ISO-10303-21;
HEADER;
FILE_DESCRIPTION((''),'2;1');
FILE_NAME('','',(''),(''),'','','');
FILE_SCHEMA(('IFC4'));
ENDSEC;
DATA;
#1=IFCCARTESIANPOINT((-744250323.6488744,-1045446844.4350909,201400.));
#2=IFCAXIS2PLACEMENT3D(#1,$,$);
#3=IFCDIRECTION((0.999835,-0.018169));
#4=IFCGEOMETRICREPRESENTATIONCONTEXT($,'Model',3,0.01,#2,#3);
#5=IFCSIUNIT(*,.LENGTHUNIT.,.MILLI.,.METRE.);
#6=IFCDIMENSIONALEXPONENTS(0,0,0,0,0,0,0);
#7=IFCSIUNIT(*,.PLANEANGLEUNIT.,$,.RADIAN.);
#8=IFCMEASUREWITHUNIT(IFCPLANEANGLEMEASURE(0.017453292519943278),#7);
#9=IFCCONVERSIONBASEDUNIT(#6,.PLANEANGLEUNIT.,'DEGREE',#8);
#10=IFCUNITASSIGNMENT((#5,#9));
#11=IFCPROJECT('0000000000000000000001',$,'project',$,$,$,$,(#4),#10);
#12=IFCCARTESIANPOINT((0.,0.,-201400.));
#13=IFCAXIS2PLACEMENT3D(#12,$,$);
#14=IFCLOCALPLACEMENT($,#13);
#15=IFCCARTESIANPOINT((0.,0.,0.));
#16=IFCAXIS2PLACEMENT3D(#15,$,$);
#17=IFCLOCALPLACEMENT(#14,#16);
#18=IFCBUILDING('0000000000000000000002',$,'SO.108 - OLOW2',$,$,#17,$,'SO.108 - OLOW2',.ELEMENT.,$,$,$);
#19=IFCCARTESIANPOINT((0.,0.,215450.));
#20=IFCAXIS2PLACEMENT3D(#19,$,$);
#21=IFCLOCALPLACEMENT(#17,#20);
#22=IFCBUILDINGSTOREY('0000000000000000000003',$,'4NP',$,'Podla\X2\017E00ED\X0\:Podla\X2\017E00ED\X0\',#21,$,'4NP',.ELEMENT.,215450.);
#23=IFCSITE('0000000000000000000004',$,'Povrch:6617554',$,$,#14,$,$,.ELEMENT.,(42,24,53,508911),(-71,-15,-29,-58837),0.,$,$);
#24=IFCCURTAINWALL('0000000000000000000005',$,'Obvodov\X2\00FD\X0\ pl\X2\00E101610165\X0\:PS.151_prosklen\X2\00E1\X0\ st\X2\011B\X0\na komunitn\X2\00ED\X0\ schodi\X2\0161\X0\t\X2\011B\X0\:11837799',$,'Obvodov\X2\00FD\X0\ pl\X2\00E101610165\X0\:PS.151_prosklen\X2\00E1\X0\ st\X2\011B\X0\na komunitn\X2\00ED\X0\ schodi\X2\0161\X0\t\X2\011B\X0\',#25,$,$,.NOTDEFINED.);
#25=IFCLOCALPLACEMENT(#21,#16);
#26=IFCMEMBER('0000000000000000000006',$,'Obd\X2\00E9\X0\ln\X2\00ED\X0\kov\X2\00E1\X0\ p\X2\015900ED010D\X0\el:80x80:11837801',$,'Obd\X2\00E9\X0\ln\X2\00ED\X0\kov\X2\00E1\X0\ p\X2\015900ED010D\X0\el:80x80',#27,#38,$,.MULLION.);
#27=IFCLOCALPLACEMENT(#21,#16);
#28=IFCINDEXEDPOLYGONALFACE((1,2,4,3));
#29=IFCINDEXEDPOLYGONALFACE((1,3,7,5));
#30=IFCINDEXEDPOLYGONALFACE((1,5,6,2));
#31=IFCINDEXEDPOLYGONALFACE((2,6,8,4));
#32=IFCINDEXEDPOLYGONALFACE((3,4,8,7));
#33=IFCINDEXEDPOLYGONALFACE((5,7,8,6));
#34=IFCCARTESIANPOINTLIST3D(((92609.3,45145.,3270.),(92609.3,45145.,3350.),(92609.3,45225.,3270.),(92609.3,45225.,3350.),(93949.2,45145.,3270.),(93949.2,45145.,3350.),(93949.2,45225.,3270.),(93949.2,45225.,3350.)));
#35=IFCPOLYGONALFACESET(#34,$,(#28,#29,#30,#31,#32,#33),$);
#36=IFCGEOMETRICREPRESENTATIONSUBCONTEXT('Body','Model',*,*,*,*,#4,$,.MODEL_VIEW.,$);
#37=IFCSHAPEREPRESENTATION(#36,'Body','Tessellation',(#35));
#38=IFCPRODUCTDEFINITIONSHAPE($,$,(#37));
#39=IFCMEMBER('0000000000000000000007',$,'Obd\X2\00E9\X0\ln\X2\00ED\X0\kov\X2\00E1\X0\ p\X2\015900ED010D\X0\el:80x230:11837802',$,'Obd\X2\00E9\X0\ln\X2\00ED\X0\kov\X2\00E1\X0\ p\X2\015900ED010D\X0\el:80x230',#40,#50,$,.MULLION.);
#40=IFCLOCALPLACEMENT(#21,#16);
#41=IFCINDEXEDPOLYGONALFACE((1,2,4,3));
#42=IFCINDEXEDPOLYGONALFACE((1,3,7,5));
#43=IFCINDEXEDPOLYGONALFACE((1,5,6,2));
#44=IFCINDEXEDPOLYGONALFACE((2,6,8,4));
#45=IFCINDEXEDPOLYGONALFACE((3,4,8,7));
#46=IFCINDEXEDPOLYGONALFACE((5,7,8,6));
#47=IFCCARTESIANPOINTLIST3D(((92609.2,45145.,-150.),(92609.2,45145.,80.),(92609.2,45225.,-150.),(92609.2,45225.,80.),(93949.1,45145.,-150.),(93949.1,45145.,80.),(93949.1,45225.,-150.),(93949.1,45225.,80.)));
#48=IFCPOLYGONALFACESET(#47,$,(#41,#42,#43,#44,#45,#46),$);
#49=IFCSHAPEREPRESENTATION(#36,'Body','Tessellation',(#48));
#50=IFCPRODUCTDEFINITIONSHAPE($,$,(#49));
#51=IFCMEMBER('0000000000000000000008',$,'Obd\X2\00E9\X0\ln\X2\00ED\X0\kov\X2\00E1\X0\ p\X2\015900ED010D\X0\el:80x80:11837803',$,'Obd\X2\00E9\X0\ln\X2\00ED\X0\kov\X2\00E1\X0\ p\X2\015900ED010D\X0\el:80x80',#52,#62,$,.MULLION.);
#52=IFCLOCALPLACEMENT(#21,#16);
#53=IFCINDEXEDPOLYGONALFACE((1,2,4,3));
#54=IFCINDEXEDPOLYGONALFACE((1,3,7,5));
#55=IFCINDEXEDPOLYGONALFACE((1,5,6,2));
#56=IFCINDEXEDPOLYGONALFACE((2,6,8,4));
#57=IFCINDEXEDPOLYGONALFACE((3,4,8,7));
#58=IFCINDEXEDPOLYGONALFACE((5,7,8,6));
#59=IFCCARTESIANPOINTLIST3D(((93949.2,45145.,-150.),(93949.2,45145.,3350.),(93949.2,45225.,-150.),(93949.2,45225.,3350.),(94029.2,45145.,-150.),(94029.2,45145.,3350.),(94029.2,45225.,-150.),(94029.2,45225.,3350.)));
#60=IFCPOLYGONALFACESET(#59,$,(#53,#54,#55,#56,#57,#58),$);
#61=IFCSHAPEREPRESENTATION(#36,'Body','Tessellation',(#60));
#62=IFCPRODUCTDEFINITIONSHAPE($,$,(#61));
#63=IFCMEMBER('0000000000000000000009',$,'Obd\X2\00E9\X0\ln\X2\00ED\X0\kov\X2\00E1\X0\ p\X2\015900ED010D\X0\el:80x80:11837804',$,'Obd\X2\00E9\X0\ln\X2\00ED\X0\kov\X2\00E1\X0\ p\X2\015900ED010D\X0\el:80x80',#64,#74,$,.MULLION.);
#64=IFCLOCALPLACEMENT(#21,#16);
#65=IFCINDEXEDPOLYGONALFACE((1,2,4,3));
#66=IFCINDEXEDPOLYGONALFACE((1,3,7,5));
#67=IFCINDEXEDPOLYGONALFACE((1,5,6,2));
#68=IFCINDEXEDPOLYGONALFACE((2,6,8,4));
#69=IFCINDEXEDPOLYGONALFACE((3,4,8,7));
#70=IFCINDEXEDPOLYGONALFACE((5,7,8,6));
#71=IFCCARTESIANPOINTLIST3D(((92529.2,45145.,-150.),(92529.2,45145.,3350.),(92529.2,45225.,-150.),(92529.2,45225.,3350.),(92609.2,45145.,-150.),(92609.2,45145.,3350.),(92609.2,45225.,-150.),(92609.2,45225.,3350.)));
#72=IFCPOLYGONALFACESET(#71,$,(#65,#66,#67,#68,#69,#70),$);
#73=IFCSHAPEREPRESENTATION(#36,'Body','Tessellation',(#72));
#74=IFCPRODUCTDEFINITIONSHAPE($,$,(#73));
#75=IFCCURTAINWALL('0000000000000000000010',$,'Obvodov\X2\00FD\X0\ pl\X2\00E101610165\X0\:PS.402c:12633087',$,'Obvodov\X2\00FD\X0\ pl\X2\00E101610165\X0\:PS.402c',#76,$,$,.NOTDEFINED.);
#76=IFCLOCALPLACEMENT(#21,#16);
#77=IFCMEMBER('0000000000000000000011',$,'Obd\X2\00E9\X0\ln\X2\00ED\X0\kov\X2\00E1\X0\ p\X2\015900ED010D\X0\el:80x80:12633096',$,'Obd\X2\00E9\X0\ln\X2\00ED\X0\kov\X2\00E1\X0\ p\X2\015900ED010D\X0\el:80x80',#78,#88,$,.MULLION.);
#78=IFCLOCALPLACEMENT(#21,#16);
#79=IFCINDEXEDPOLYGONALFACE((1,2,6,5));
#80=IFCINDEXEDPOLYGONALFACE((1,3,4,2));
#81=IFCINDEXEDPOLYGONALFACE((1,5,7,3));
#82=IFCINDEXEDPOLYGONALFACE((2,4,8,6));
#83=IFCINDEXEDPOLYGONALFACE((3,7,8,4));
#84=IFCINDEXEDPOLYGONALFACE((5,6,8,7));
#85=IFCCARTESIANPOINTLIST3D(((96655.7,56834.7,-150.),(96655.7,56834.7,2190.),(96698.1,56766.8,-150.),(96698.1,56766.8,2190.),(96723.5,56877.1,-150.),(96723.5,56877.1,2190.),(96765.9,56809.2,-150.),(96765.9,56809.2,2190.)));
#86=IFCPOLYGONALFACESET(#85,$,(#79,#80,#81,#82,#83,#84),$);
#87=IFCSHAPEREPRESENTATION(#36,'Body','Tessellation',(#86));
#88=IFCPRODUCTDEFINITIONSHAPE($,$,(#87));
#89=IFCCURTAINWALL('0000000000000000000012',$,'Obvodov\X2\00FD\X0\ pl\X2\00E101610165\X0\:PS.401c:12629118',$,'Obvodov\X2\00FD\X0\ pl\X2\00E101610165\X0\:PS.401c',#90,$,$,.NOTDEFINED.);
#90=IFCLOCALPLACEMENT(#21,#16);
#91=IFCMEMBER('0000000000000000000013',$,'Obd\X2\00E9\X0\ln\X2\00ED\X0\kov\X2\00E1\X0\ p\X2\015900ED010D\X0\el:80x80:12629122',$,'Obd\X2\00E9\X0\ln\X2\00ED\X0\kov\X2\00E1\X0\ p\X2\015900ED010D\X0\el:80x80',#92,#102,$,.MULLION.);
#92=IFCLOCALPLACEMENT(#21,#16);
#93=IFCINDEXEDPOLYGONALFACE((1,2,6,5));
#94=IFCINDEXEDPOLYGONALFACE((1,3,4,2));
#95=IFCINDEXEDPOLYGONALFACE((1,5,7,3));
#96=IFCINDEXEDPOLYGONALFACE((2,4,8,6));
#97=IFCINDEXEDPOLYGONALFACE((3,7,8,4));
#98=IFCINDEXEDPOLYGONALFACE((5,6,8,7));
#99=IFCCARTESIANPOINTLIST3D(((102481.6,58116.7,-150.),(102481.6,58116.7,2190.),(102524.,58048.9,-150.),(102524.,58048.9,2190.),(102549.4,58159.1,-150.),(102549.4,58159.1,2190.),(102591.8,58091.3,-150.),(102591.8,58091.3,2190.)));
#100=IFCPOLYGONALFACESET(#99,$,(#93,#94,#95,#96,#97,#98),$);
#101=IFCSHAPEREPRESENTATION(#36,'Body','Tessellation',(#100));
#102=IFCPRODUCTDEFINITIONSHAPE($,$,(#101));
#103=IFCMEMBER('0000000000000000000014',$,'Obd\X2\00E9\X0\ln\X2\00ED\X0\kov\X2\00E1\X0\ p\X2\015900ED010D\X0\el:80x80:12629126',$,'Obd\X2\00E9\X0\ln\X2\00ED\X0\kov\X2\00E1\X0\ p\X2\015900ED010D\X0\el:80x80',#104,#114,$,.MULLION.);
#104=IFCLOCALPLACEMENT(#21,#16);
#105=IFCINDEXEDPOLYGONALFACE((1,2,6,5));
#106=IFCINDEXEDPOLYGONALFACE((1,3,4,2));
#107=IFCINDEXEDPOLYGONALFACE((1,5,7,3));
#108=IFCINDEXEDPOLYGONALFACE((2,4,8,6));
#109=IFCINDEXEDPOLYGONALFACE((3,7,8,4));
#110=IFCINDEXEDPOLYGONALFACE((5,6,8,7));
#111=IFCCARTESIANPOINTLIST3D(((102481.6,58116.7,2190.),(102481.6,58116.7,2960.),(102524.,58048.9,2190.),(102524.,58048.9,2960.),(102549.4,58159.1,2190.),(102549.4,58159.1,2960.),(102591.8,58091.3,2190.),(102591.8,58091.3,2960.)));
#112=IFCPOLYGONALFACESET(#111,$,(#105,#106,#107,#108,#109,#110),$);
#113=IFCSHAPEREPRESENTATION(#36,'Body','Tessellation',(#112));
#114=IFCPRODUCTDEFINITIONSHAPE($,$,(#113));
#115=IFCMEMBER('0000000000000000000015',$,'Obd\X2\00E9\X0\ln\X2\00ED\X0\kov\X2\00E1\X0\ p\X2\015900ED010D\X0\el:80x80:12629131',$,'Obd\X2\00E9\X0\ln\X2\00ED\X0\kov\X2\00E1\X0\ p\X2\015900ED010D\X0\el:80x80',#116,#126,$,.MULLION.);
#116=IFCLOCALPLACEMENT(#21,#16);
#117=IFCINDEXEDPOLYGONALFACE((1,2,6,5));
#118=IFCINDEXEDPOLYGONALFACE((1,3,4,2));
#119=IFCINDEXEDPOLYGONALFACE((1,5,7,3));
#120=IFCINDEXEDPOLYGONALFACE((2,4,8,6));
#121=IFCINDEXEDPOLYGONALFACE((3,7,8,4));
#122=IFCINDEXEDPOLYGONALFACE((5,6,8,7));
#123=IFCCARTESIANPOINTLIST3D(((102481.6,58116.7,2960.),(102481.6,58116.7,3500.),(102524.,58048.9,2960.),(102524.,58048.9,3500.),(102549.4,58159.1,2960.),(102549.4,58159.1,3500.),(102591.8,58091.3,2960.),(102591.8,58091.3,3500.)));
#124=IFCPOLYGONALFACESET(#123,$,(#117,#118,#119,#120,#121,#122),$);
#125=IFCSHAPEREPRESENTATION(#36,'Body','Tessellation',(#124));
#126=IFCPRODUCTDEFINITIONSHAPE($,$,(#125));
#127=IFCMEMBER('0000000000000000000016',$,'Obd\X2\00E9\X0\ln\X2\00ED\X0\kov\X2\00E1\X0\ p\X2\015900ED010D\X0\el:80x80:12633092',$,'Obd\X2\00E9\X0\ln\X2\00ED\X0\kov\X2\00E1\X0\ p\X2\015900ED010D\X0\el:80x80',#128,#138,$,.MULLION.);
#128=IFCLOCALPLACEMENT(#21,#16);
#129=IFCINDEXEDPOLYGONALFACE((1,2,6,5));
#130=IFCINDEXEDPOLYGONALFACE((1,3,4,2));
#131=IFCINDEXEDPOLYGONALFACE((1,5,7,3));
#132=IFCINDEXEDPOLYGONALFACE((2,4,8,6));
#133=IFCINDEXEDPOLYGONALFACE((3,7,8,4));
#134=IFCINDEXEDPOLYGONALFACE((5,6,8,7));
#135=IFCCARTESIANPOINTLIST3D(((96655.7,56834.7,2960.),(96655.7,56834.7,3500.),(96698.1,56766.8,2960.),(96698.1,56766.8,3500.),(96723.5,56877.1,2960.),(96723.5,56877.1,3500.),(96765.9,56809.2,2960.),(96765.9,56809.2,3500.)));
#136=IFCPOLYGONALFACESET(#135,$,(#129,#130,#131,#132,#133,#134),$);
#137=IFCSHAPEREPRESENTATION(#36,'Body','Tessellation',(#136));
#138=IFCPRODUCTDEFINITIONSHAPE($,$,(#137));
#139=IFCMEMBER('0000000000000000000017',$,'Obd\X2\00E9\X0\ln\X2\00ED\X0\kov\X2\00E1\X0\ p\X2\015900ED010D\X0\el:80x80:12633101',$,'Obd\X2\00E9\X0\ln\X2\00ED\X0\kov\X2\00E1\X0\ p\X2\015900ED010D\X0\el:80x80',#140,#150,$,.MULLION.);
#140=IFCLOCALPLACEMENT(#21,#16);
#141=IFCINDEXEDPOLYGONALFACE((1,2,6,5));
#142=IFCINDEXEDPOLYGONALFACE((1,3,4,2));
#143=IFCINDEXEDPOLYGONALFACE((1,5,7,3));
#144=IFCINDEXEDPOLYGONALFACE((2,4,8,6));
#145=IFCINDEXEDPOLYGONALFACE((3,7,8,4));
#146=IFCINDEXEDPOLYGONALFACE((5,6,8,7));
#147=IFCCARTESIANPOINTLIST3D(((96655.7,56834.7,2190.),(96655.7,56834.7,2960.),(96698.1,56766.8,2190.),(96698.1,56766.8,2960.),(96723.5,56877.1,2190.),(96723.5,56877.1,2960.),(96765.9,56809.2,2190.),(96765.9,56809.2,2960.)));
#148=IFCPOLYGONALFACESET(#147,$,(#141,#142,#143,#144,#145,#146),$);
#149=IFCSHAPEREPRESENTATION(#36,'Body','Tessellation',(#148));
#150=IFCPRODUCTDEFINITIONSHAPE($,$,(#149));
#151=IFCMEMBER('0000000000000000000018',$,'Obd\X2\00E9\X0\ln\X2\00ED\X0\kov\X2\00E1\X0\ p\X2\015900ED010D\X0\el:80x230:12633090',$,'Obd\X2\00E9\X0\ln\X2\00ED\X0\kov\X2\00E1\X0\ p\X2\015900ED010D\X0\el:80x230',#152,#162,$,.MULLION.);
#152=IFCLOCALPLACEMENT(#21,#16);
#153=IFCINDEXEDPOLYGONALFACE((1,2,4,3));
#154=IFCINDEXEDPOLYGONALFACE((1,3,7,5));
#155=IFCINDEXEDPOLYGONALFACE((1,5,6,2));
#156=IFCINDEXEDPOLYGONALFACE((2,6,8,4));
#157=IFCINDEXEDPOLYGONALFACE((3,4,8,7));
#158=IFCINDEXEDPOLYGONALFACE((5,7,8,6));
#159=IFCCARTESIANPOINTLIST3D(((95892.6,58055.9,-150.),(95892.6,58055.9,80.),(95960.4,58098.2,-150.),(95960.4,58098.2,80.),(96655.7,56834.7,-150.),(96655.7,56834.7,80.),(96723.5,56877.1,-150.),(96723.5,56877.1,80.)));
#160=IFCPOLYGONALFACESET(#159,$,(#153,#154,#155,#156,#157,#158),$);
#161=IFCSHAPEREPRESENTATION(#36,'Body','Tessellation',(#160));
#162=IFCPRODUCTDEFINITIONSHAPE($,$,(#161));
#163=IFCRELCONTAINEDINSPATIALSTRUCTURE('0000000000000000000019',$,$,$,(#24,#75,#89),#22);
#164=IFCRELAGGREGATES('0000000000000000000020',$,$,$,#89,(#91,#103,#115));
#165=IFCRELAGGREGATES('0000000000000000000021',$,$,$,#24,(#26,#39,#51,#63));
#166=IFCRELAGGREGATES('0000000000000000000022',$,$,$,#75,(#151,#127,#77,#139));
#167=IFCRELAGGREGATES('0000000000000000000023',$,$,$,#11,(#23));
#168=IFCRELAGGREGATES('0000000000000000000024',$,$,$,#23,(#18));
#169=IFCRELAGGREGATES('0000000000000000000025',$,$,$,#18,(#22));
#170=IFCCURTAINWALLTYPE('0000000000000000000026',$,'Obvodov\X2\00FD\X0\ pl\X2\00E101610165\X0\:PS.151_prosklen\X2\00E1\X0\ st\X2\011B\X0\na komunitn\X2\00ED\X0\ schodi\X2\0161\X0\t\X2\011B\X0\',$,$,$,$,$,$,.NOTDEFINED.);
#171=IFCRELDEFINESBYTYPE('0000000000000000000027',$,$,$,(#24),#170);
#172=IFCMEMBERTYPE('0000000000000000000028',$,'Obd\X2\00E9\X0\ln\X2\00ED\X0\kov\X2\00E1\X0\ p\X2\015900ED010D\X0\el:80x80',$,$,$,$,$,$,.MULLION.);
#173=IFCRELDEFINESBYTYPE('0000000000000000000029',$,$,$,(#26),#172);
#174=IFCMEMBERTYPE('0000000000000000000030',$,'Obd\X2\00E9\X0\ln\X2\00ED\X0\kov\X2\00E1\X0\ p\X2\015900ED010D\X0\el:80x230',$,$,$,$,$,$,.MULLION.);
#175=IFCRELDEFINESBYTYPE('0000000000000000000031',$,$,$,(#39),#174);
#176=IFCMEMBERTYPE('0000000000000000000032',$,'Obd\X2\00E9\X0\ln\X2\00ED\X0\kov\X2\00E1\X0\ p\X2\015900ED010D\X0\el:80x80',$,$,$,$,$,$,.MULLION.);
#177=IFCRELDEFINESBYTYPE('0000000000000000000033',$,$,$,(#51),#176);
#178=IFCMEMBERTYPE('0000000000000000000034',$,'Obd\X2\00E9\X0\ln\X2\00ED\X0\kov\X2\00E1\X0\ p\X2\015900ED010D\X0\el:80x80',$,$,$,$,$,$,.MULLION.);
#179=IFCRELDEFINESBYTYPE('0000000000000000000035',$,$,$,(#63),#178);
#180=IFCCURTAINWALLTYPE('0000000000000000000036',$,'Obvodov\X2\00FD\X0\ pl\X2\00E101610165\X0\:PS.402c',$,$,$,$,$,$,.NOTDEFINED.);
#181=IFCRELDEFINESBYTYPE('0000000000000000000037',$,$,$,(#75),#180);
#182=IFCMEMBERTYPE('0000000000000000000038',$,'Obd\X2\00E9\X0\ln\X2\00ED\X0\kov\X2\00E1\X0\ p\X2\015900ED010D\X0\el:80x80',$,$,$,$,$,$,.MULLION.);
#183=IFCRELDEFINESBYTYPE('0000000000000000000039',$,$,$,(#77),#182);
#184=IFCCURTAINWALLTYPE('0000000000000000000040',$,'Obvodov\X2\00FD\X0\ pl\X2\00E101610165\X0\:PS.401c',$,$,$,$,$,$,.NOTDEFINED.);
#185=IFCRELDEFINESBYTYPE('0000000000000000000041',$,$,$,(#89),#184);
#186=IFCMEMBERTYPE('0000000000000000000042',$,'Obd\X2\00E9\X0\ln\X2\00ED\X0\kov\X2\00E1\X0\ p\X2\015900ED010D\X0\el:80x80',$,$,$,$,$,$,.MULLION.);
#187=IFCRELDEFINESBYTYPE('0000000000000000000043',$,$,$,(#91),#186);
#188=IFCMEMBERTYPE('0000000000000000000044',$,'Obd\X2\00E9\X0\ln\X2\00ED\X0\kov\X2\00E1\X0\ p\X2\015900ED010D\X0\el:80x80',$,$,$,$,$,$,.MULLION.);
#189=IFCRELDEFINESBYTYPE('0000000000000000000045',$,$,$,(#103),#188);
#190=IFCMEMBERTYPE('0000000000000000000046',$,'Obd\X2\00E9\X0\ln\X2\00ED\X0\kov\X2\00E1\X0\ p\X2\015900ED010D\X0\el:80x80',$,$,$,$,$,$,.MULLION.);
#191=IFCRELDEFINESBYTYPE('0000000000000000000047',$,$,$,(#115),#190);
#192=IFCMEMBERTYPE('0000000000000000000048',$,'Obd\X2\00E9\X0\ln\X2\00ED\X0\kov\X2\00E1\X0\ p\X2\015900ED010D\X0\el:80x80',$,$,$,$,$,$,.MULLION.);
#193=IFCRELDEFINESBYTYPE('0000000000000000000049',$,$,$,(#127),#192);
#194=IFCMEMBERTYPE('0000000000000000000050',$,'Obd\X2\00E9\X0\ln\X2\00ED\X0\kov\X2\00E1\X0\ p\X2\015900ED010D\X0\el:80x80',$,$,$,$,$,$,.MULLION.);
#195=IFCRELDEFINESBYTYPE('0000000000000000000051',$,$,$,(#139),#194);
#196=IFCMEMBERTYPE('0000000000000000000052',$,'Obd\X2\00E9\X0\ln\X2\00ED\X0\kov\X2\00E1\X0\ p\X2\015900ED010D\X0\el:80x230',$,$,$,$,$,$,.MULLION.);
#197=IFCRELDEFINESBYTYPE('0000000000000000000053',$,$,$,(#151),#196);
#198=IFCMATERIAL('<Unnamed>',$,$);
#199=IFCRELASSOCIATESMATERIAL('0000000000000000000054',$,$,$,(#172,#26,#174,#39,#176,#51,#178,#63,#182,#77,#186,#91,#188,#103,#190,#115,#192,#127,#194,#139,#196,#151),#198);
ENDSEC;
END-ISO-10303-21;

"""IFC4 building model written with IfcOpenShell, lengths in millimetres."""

from ifc_helpers import new_model, entity, si_unit, converted_unit, direction, frame, origin, place, context, subcontext, project, spatial, indexed_curve, outline, extrude, source, transform, mapped, material, type_object, type_shapes, element, aggregate, save


model = new_model("IFC4")

# Units and contexts
model_context = context("Model", 3, precision=0.01, world=frame((-744250323.6488744, -1045446844.4350909, 201400.0)), true_north=direction((0.999835, -0.018169)))
body_context = subcontext(model_context, "Body", "Model", "MODEL_VIEW")
ifc_project = project(units=[si_unit("LENGTHUNIT", "METRE", prefix="MILLI"), converted_unit("PLANEANGLEUNIT", "DEGREE", entity("IfcPlaneAngleMeasure", 0.017453292519943278), si_unit("PLANEANGLEUNIT", "RADIAN"), dimensions=[0, 0, 0, 0, 0, 0, 0])], contexts=[model_context])

# Site, building, storey
site_placement = place(None, frame((0.0, 0.0, -201400.0)))
site = spatial("IfcSite", under=ifc_project, at=site_placement, Name="Povrch:6617554", CompositionType="ELEMENT", RefLatitude=(42, 24, 53, 508911), RefLongitude=(-71, -15, -29, -58837), RefElevation=0.0)
building_placement = place(site_placement, origin())
building = spatial("IfcBuilding", under=site, at=building_placement, Name="SO.108 - OLOW2", LongName="SO.108 - OLOW2", CompositionType="ELEMENT")
storey_placement = place(building_placement, frame((0.0, 0.0, 215450.0)))
storey = spatial("IfcBuildingStorey", under=building, at=storey_placement, Name="4NP", ObjectType="Podlaží:Podlaží", LongName="4NP", CompositionType="ELEMENT", Elevation=215450.0)

# Curtain wall, members
curtain_wall_type_1 = type_object("IfcCurtainWallType", Name="Obvodový plášť:PS.151_prosklená stěna komunitní schodiště", PredefinedType="NOTDEFINED")
curtain_wall_1_placement = place(storey_placement, frame((0.0, 0.0, -215450.0)))
curtain_wall_1 = element("IfcCurtainWall", 1, at=curtain_wall_1_placement, inside=storey, type_object=curtain_wall_type_1, Name="Obvodový plášť:PS.151_prosklená stěna komunitní schodiště:11837799", ObjectType="Obvodový plášť:PS.151_prosklená stěna komunitní schodiště", PredefinedType="NOTDEFINED")
ifc_material_1 = material(Name="<Unnamed>")
member_type_1 = type_object("IfcMemberType", Name="Obdélníková příčel:80x80", PredefinedType="MULLION", material=ifc_material_1)
shared_shape_1 = source(origin(), body_context, "Body", "SweptSolid", [
    extrude(outline(indexed_curve([(-40.0, -40.0), (40.0, -40.0), (40.0, 40.0), (-40.0, 40.0), (-40.0, -40.0)], self_intersect=False)), frame((-40.0, 0.0, -1339.9), z_axis=(0.0, 0.0, 1.0), x_axis=(-1.0, 0.0, 0.0)), (0.0, 0.0, 1.0), 1339.9),
])
type_shapes(member_type_1, [shared_shape_1])
member_1_placement = place(curtain_wall_1_placement, frame((93949.2, 45185.0, 218800.0), z_axis=(1.0, 0.0, 0.0), x_axis=(0.0, 0.0, 1.0)))
member_1 = element("IfcMember", 2, at=member_1_placement, type_object=member_type_1, material=ifc_material_1, Name="Obdélníková příčel:80x80:11837801", ObjectType="Obdélníková příčel:80x80", PredefinedType="MULLION", context=body_context, shape_type="MappedRepresentation", body=[
    mapped(shared_shape_1, transform((0.0, 0.0, 0.0), scale=1.0)),
])
member_type_2 = type_object("IfcMemberType", Name="Obdélníková příčel:80x230", PredefinedType="MULLION", material=ifc_material_1)
shared_shape_2 = source(origin(), body_context, "Body", "SweptSolid", [
    extrude(outline(indexed_curve([(-115.0, -40.0), (115.0, -40.0), (115.0, 40.0), (-115.0, 40.0), (-115.0, -40.0)], self_intersect=False)), frame((-115.0, 0.0, -1339.9), z_axis=(0.0, 0.0, 1.0), x_axis=(-1.0, 0.0, 0.0)), (0.0, 0.0, 1.0), 1339.9),
])
type_shapes(member_type_2, [shared_shape_2])
member_2_placement = place(curtain_wall_1_placement, frame((92609.2, 45185.0, 215300.0), z_axis=(-1.0, 0.0, 0.0), x_axis=(0.0, 0.0, -1.0)))
member_2 = element("IfcMember", 3, at=member_2_placement, type_object=member_type_2, material=ifc_material_1, Name="Obdélníková příčel:80x230:11837802", ObjectType="Obdélníková příčel:80x230", PredefinedType="MULLION", context=body_context, shape_type="MappedRepresentation", body=[
    mapped(shared_shape_2, transform((0.0, 0.0, 0.0), scale=1.0)),
])
member_type_3 = type_object("IfcMemberType", Name="Obdélníková příčel:80x80", PredefinedType="MULLION", material=ifc_material_1)
shared_shape_3 = source(origin(), body_context, "Body", "SweptSolid", [
    extrude(outline(indexed_curve([(-40.0, -40.0), (40.0, -40.0), (40.0, 40.0), (-40.0, 40.0), (-40.0, -40.0)], self_intersect=False)), frame((-40.0, 0.0, -3500.0), z_axis=(0.0, 0.0, 1.0), x_axis=(-1.0, 0.0, 0.0)), (0.0, 0.0, 1.0), 3500.0),
])
type_shapes(member_type_3, [shared_shape_3])
member_3_placement = place(curtain_wall_1_placement, frame((94029.2, 45185.0, 215300.0), z_axis=(0.0, 0.0, -1.0), x_axis=(1.0, 0.0, 0.0)))
member_3 = element("IfcMember", 4, at=member_3_placement, type_object=member_type_3, material=ifc_material_1, Name="Obdélníková příčel:80x80:11837803", ObjectType="Obdélníková příčel:80x80", PredefinedType="MULLION", context=body_context, shape_type="MappedRepresentation", body=[
    mapped(shared_shape_3, transform((0.0, 0.0, 0.0), scale=1.0)),
])
member_type_4 = type_object("IfcMemberType", Name="Obdélníková příčel:80x80", PredefinedType="MULLION", material=ifc_material_1)
shared_shape_4 = source(origin(), body_context, "Body", "SweptSolid", [
    extrude(outline(indexed_curve([(-40.0, -40.0), (40.0, -40.0), (40.0, 40.0), (-40.0, 40.0), (-40.0, -40.0)], self_intersect=False)), frame((-40.0, 0.0, -3500.0), z_axis=(0.0, 0.0, 1.0), x_axis=(-1.0, 0.0, 0.0)), (0.0, 0.0, 1.0), 3500.0),
])
type_shapes(member_type_4, [shared_shape_4])
member_4_placement = place(curtain_wall_1_placement, frame((92529.2, 45185.0, 218800.0), z_axis=(0.0, 0.0, 1.0), x_axis=(-1.0, 0.0, 0.0)))
member_4 = element("IfcMember", 5, at=member_4_placement, type_object=member_type_4, material=ifc_material_1, Name="Obdélníková příčel:80x80:11837804", ObjectType="Obdélníková příčel:80x80", PredefinedType="MULLION", context=body_context, shape_type="MappedRepresentation", body=[
    mapped(shared_shape_4, transform((0.0, 0.0, 0.0), scale=1.0)),
])

# Curtain wall, member
curtain_wall_type_2 = type_object("IfcCurtainWallType", Name="Obvodový plášť:PS.402c", PredefinedType="NOTDEFINED")
curtain_wall_2_placement = place(storey_placement, frame((0.0, 0.0, -215450.0)))
curtain_wall_2 = element("IfcCurtainWall", 6, at=curtain_wall_2_placement, inside=storey, type_object=curtain_wall_type_2, Name="Obvodový plášť:PS.402c:12633087", ObjectType="Obvodový plášť:PS.402c", PredefinedType="NOTDEFINED")
member_type_5 = type_object("IfcMemberType", Name="Obdélníková příčel:80x80", PredefinedType="MULLION", material=ifc_material_1)
shared_shape_5 = source(origin(), body_context, "Body", "SweptSolid", [
    extrude(outline(indexed_curve([(-40.0, -40.0), (40.0, -40.0), (40.0, 40.0), (-40.0, 40.0), (-40.0, -40.0)], self_intersect=False)), frame((-40.0, 0.0, -2340.0), z_axis=(0.0, 0.0, 1.0), x_axis=(-1.0, 0.0, 0.0)), (0.0, 0.0, 1.0), 2340.0),
])
type_shapes(member_type_5, [shared_shape_5])
member_5_placement = place(curtain_wall_2_placement, frame((96732.0, 56788.0, 217640.0), z_axis=(0.0, 0.0, 1.0), x_axis=(0.529919, -0.848048, 0.0)))
member_5 = element("IfcMember", 7, at=member_5_placement, type_object=member_type_5, material=ifc_material_1, Name="Obdélníková příčel:80x80:12633096", ObjectType="Obdélníková příčel:80x80", PredefinedType="MULLION", context=body_context, shape_type="MappedRepresentation", body=[
    mapped(shared_shape_5, transform((0.0, 0.0, 0.0), scale=1.0)),
])

# Curtain wall, members
curtain_wall_type_3 = type_object("IfcCurtainWallType", Name="Obvodový plášť:PS.401c", PredefinedType="NOTDEFINED")
curtain_wall_3_placement = place(storey_placement, frame((0.0, 0.0, -215450.0)))
curtain_wall_3 = element("IfcCurtainWall", 8, at=curtain_wall_3_placement, inside=storey, type_object=curtain_wall_type_3, Name="Obvodový plášť:PS.401c:12629118", ObjectType="Obvodový plášť:PS.401c", PredefinedType="NOTDEFINED")
member_type_6 = type_object("IfcMemberType", Name="Obdélníková příčel:80x80", PredefinedType="MULLION", material=ifc_material_1)
shared_shape_6 = source(origin(), body_context, "Body", "SweptSolid", [
    extrude(outline(indexed_curve([(-40.0, -40.0), (40.0, -40.0), (40.0, 40.0), (-40.0, 40.0), (-40.0, -40.0)], self_intersect=False)), frame((-40.0, 0.0, -2340.0), z_axis=(0.0, 0.0, 1.0), x_axis=(-1.0, 0.0, 0.0)), (0.0, 0.0, 1.0), 2340.0),
])
type_shapes(member_type_6, [shared_shape_6])
member_6_placement = place(curtain_wall_3_placement, frame((102557.9, 58070.1, 215300.0), z_axis=(0.0, 0.0, -1.0), x_axis=(0.529919, -0.848048, 0.0)))
member_6 = element("IfcMember", 9, at=member_6_placement, type_object=member_type_6, material=ifc_material_1, Name="Obdélníková příčel:80x80:12629122", ObjectType="Obdélníková příčel:80x80", PredefinedType="MULLION", context=body_context, shape_type="MappedRepresentation", body=[
    mapped(shared_shape_6, transform((0.0, 0.0, 0.0), scale=1.0)),
])
member_type_7 = type_object("IfcMemberType", Name="Obdélníková příčel:80x80", PredefinedType="MULLION", material=ifc_material_1)
shared_shape_7 = source(origin(), body_context, "Body", "SweptSolid", [
    extrude(outline(indexed_curve([(-40.0, -40.0), (40.0, -40.0), (40.0, 40.0), (-40.0, 40.0), (-40.0, -40.0)], self_intersect=False)), frame((-40.0, 0.0, -770.0), z_axis=(0.0, 0.0, 1.0), x_axis=(-1.0, 0.0, 0.0)), (0.0, 0.0, 1.0), 770.0),
])
type_shapes(member_type_7, [shared_shape_7])
member_7_placement = place(curtain_wall_3_placement, frame((102557.9, 58070.1, 217640.0), z_axis=(0.0, 0.0, -1.0), x_axis=(0.529919, -0.848048, 0.0)))
member_7 = element("IfcMember", 10, at=member_7_placement, type_object=member_type_7, material=ifc_material_1, Name="Obdélníková příčel:80x80:12629126", ObjectType="Obdélníková příčel:80x80", PredefinedType="MULLION", context=body_context, shape_type="MappedRepresentation", body=[
    mapped(shared_shape_7, transform((0.0, 0.0, 0.0), scale=1.0)),
])
member_type_8 = type_object("IfcMemberType", Name="Obdélníková příčel:80x80", PredefinedType="MULLION", material=ifc_material_1)
shared_shape_8 = source(origin(), body_context, "Body", "SweptSolid", [
    extrude(outline(indexed_curve([(-40.0, -40.0), (40.0, -40.0), (40.0, 40.0), (-40.0, 40.0), (-40.0, -40.0)], self_intersect=False)), frame((-40.0, 0.0, -540.0), z_axis=(0.0, 0.0, 1.0), x_axis=(-1.0, 0.0, 0.0)), (0.0, 0.0, 1.0), 540.0),
])
type_shapes(member_type_8, [shared_shape_8])
member_8_placement = place(curtain_wall_3_placement, frame((102557.9, 58070.1, 218410.0), z_axis=(0.0, 0.0, -1.0), x_axis=(0.529919, -0.848048, 0.0)))
member_8 = element("IfcMember", 11, at=member_8_placement, type_object=member_type_8, material=ifc_material_1, Name="Obdélníková příčel:80x80:12629131", ObjectType="Obdélníková příčel:80x80", PredefinedType="MULLION", context=body_context, shape_type="MappedRepresentation", body=[
    mapped(shared_shape_8, transform((0.0, 0.0, 0.0), scale=1.0)),
])
aggregate(curtain_wall_3, [member_6, member_7, member_8])

# Members
member_type_9 = type_object("IfcMemberType", Name="Obdélníková příčel:80x80", PredefinedType="MULLION", material=ifc_material_1)
shared_shape_9 = source(origin(), body_context, "Body", "SweptSolid", [
    extrude(outline(indexed_curve([(-40.0, -40.0), (40.0, -40.0), (40.0, 40.0), (-40.0, 40.0), (-40.0, -40.0)], self_intersect=False)), frame((-40.0, 0.0, -540.0), z_axis=(0.0, 0.0, 1.0), x_axis=(-1.0, 0.0, 0.0)), (0.0, 0.0, 1.0), 540.0),
])
type_shapes(member_type_9, [shared_shape_9])
member_9_placement = place(curtain_wall_2_placement, frame((96732.0, 56788.0, 218950.0), z_axis=(0.0, 0.0, 1.0), x_axis=(0.529919, -0.848048, 0.0)))
member_9 = element("IfcMember", 12, at=member_9_placement, type_object=member_type_9, material=ifc_material_1, Name="Obdélníková příčel:80x80:12633092", ObjectType="Obdélníková příčel:80x80", PredefinedType="MULLION", context=body_context, shape_type="MappedRepresentation", body=[
    mapped(shared_shape_9, transform((0.0, 0.0, 0.0), scale=1.0)),
])
member_type_10 = type_object("IfcMemberType", Name="Obdélníková příčel:80x80", PredefinedType="MULLION", material=ifc_material_1)
shared_shape_10 = source(origin(), body_context, "Body", "SweptSolid", [
    extrude(outline(indexed_curve([(-40.0, -40.0), (40.0, -40.0), (40.0, 40.0), (-40.0, 40.0), (-40.0, -40.0)], self_intersect=False)), frame((-40.0, 0.0, -770.0), z_axis=(0.0, 0.0, 1.0), x_axis=(-1.0, 0.0, 0.0)), (0.0, 0.0, 1.0), 770.0),
])
type_shapes(member_type_10, [shared_shape_10])
member_10_placement = place(curtain_wall_2_placement, frame((96732.0, 56788.0, 218410.0), z_axis=(0.0, 0.0, 1.0), x_axis=(0.529919, -0.848048, 0.0)))
member_10 = element("IfcMember", 13, at=member_10_placement, type_object=member_type_10, material=ifc_material_1, Name="Obdélníková příčel:80x80:12633101", ObjectType="Obdélníková příčel:80x80", PredefinedType="MULLION", context=body_context, shape_type="MappedRepresentation", body=[
    mapped(shared_shape_10, transform((0.0, 0.0, 0.0), scale=1.0)),
])
member_type_11 = type_object("IfcMemberType", Name="Obdélníková příčel:80x230", PredefinedType="MULLION", material=ifc_material_1)
shared_shape_11 = source(origin(), body_context, "Body", "SweptSolid", [
    extrude(outline(indexed_curve([(-115.0, -40.0), (115.0, -40.0), (115.0, 40.0), (-115.0, 40.0), (-115.0, -40.0)], self_intersect=False)), frame((-115.0, 0.0, -1440.0), z_axis=(0.0, 0.0, 1.0), x_axis=(-1.0, 0.0, 0.0)), (0.0, 0.0, 1.0), 1440.0),
])
type_shapes(member_type_11, [shared_shape_11])
member_11_placement = place(curtain_wall_2_placement, frame((96689.6, 56855.9, 215300.0), z_axis=(0.529919, -0.848048, 0.0), x_axis=(0.0, 0.0, -1.0)))
member_11 = element("IfcMember", 14, at=member_11_placement, type_object=member_type_11, material=ifc_material_1, Name="Obdélníková příčel:80x230:12633090", ObjectType="Obdélníková příčel:80x230", PredefinedType="MULLION", context=body_context, shape_type="MappedRepresentation", body=[
    mapped(shared_shape_11, transform((0.0, 0.0, 0.0), scale=1.0)),
])

aggregate(curtain_wall_1, [member_1, member_2, member_3, member_4])
aggregate(curtain_wall_2, [member_11, member_9, member_5, member_10])

save(model, "model.ifc")
